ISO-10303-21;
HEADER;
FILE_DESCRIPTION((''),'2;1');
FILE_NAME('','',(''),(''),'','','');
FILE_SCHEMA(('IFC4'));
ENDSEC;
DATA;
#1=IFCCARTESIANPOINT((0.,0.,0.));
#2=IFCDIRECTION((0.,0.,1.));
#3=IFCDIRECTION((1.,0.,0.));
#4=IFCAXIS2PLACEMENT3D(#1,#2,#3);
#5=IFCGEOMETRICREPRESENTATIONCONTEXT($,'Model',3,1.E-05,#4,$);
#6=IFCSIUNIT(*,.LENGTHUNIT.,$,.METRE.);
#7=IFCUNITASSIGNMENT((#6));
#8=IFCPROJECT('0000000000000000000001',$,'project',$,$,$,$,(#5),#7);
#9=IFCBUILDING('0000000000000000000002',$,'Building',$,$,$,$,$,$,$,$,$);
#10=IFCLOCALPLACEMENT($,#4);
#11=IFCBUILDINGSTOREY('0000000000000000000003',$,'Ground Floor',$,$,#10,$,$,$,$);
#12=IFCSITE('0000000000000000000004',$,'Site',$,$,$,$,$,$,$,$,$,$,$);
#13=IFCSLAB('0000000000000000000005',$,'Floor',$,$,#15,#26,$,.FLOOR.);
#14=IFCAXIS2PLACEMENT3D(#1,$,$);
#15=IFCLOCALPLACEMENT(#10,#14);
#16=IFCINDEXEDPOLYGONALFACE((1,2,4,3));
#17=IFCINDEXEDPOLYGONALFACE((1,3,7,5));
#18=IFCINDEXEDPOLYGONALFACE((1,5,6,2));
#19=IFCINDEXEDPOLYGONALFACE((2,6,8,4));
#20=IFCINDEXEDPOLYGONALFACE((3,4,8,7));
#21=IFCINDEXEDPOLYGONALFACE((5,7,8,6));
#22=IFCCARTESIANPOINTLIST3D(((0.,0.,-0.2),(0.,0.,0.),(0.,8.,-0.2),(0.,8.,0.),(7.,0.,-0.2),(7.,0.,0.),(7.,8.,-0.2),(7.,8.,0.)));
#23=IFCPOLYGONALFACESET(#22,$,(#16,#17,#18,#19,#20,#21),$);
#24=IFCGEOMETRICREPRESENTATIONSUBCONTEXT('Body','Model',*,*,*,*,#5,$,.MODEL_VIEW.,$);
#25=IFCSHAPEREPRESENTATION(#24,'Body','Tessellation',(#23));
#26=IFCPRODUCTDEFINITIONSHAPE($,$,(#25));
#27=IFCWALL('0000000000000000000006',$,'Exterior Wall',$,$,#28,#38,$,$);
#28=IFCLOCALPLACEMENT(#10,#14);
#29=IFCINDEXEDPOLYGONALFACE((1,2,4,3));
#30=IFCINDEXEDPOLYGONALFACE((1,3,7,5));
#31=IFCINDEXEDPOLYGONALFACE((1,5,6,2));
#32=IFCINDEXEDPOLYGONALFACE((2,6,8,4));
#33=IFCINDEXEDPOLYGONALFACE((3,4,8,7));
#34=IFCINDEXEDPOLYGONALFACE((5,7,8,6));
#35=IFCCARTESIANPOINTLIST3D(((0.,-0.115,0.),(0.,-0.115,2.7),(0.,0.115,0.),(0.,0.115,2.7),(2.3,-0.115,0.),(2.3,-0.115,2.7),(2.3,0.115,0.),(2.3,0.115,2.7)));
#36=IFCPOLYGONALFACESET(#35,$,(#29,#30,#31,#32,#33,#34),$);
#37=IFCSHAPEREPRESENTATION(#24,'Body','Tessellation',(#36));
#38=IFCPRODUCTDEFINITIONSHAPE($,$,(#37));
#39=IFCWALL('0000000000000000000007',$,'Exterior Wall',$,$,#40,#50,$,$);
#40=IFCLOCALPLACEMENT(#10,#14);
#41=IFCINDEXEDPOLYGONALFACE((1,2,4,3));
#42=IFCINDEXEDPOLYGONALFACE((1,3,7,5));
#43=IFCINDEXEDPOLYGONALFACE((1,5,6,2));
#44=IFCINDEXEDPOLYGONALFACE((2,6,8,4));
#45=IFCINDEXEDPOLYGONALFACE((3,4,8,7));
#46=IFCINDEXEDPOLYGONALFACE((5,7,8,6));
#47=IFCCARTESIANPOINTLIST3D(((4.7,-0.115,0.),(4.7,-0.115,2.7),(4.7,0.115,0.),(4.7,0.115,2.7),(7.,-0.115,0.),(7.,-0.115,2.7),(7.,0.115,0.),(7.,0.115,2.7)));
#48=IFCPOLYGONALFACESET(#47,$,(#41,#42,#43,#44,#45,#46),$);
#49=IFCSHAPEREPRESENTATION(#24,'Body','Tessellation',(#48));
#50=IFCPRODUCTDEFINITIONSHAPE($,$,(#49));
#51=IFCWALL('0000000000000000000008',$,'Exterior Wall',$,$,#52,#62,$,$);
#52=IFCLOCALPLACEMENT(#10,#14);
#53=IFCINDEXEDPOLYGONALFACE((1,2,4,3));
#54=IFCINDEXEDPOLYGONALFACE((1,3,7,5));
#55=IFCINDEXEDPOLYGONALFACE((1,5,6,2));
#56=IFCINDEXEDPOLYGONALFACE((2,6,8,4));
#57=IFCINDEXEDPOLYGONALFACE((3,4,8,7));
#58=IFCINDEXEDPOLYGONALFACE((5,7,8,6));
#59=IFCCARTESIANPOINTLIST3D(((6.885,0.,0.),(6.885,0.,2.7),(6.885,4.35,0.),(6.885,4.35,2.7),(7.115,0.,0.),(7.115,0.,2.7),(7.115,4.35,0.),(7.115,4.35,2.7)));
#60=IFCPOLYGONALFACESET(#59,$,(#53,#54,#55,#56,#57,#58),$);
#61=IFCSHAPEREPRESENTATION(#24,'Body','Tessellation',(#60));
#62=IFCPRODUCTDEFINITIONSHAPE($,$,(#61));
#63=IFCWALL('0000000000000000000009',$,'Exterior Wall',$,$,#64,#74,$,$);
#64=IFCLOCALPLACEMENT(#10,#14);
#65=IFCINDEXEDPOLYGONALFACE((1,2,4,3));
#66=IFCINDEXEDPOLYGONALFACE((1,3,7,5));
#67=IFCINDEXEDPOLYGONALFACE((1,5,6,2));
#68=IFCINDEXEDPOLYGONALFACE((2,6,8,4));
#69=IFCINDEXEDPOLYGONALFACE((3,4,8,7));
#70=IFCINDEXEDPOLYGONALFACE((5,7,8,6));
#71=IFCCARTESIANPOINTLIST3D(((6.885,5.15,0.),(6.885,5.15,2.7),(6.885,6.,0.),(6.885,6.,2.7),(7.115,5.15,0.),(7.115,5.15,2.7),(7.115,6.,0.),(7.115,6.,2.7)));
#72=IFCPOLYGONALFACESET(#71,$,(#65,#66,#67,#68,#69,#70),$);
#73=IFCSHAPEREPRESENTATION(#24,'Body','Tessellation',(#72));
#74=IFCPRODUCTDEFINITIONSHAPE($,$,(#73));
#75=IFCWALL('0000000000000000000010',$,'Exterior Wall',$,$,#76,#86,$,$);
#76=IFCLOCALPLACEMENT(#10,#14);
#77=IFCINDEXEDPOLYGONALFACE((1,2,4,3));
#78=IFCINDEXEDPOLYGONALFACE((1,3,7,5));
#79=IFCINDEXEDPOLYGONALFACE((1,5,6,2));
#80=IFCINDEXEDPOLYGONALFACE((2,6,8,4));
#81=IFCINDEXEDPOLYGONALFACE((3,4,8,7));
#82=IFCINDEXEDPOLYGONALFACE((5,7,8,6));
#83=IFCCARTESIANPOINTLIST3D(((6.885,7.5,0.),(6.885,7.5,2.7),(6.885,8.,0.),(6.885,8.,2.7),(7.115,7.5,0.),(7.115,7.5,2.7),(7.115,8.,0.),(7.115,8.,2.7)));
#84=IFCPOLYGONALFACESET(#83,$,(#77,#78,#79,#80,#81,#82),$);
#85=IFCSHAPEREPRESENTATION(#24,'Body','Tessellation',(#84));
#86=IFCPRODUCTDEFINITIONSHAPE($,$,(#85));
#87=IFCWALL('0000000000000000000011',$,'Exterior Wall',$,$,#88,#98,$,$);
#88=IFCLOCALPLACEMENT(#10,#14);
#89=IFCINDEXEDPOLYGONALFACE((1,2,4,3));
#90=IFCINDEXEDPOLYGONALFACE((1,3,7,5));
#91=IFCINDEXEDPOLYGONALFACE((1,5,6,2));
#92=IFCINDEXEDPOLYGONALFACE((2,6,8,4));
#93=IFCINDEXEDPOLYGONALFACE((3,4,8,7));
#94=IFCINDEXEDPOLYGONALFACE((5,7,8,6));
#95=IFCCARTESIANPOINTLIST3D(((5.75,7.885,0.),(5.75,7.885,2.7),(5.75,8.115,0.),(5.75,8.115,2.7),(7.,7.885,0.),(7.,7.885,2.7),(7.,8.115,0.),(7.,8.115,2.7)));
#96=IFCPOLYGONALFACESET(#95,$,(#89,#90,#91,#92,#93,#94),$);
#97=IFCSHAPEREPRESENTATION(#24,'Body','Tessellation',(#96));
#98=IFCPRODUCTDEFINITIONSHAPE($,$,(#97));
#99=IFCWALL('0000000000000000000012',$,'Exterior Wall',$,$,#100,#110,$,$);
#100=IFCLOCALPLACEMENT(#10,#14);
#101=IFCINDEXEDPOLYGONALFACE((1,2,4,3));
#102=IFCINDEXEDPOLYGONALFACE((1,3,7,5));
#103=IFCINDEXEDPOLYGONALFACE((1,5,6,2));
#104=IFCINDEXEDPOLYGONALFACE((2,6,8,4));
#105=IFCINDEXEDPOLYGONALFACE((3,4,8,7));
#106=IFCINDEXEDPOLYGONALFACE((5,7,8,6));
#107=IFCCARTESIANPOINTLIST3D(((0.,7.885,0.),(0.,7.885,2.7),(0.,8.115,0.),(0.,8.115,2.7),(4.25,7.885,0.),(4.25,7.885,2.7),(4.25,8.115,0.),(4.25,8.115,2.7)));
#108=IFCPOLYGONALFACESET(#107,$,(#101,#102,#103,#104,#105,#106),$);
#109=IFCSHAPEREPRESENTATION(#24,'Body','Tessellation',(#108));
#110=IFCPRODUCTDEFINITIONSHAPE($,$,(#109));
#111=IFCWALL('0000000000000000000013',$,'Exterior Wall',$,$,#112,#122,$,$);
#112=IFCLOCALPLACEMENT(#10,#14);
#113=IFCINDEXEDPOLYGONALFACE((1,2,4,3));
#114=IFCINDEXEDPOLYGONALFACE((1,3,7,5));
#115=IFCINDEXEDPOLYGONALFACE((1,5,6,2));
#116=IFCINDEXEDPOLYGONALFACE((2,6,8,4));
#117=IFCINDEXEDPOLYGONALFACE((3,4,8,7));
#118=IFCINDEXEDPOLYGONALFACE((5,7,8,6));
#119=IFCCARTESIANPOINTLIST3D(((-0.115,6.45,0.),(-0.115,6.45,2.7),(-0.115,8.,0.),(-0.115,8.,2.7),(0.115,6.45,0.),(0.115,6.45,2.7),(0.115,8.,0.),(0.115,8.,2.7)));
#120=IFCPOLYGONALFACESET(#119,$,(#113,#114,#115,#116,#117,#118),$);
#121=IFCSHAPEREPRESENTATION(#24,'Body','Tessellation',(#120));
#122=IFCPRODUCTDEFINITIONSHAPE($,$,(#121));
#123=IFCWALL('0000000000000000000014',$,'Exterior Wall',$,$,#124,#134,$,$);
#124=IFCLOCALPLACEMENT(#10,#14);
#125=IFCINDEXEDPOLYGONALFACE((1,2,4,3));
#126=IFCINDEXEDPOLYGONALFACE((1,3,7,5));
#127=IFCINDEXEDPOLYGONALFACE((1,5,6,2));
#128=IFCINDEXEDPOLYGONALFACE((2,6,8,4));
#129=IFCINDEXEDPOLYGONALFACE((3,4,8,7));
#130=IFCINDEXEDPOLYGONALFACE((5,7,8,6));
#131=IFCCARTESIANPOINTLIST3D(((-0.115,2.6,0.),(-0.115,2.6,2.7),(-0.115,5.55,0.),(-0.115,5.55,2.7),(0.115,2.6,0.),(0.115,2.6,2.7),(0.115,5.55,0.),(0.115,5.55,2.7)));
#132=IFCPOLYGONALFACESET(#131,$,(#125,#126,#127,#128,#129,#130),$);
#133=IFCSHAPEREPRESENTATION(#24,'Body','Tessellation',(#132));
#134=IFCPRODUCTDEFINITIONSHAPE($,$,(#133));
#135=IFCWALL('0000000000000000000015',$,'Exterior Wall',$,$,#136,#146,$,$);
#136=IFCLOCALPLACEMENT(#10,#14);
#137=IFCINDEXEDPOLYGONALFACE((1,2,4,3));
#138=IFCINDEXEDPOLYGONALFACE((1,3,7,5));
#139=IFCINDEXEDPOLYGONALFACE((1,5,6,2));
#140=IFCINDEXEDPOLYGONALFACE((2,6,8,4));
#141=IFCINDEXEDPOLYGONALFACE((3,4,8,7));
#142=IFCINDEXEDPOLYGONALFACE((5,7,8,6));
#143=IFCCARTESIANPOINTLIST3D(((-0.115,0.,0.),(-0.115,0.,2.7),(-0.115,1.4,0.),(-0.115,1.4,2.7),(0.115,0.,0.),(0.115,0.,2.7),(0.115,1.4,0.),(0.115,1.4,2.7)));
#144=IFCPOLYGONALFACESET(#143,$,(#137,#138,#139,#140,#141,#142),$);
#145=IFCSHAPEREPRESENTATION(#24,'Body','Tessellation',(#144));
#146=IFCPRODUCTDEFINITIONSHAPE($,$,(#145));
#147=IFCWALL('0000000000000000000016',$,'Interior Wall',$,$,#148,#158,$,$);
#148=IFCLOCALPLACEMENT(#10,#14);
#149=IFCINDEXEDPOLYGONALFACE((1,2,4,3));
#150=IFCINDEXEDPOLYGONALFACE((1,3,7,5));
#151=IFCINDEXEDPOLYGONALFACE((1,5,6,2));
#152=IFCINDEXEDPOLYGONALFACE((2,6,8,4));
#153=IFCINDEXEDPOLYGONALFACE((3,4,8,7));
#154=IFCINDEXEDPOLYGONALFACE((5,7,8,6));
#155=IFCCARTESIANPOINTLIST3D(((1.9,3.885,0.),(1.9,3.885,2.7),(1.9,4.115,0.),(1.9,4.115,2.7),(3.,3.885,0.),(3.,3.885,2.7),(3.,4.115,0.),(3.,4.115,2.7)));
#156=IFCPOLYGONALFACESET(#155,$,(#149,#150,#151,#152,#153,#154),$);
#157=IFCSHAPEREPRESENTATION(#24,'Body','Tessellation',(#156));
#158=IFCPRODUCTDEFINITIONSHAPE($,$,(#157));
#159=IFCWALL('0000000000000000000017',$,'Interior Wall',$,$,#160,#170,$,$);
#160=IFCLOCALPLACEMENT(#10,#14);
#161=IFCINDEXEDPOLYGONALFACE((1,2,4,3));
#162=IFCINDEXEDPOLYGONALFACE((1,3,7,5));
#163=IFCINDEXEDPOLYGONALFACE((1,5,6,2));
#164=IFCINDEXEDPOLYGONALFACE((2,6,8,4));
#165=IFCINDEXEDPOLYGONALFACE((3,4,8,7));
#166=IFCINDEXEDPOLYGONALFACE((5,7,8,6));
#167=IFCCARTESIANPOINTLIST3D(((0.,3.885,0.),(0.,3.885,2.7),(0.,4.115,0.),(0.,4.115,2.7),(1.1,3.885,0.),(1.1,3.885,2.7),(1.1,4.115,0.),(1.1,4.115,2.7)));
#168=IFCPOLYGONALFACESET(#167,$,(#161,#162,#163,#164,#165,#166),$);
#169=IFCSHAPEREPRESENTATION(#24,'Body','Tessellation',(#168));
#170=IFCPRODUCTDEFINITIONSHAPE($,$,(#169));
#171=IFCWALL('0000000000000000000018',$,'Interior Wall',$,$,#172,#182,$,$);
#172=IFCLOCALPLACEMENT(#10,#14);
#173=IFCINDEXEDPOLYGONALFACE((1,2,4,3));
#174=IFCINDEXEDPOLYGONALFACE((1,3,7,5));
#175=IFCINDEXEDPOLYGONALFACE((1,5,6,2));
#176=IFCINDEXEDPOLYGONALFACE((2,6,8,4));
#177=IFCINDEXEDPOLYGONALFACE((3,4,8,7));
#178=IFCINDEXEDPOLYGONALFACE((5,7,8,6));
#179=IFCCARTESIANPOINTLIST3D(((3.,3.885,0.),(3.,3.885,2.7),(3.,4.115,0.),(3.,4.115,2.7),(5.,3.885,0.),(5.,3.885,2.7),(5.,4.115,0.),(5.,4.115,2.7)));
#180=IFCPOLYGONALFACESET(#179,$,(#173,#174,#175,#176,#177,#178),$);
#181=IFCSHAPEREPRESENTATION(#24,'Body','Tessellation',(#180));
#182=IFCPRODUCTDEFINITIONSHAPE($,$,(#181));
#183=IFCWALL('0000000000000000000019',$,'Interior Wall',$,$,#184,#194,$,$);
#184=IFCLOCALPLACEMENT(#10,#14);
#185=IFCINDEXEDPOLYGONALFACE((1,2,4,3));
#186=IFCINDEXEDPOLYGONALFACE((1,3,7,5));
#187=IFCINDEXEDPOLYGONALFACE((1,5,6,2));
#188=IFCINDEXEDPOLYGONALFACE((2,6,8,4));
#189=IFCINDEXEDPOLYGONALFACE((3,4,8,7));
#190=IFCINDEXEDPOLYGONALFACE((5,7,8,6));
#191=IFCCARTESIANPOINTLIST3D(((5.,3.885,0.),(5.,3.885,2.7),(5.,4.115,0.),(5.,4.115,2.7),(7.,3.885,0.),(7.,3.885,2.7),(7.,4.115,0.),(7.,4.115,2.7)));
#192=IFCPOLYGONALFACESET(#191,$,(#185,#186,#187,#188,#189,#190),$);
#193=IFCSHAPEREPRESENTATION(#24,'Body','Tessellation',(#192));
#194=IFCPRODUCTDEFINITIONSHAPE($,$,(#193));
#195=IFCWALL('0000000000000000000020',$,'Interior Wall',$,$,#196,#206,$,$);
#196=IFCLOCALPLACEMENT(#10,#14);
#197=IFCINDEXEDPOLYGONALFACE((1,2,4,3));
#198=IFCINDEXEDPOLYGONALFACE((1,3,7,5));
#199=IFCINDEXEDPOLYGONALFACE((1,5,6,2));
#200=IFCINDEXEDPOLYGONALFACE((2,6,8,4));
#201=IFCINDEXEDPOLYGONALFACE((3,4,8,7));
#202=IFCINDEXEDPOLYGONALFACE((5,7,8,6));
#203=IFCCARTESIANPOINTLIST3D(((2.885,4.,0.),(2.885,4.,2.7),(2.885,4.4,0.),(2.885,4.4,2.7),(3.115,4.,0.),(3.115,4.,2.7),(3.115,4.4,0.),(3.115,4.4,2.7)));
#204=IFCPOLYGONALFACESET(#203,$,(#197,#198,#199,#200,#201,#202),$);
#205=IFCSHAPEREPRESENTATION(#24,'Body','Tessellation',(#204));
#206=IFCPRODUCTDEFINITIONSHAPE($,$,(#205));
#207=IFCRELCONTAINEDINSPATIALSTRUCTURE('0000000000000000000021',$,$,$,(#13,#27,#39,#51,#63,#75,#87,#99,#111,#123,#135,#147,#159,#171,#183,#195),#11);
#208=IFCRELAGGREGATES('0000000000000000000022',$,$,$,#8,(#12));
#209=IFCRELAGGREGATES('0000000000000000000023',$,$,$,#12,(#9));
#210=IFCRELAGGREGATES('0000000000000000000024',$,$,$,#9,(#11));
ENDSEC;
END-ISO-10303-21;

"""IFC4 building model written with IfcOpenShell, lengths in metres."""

from ifc_helpers import new_model, si_unit, frame, origin_with_axes, place, context, subcontext, project, spatial, indexed_curve, outline, extrude, element, save


model = new_model("IFC4")

# Units and contexts
model_context = context("Model", 3, precision=1e-05, world=origin_with_axes())
body_context = subcontext(model_context, "Body", "Model", "MODEL_VIEW")
ifc_project = project(units=[si_unit("LENGTHUNIT", "METRE")], contexts=[model_context])

# Site, building, storey
site = spatial("IfcSite", under=ifc_project, Name="Site")
building = spatial("IfcBuilding", under=site, Name="Building")
storey_placement = place(None, origin_with_axes())
storey = spatial("IfcBuildingStorey", under=building, at=storey_placement, Name="Ground Floor")

# Slab
slab_placement = place(storey_placement, frame((0.0, 0.0, -0.2), z_axis=(0.0, 0.0, 1.0), x_axis=(1.0, 0.0, 0.0)))
element("IfcSlab", 1, at=slab_placement, inside=storey, Name="Floor", PredefinedType="FLOOR", context=body_context, shape_type="SweptSolid", body=[
    extrude(outline(indexed_curve([(0.0, 0.0), (7.0, 0.0), (7.0, 8.0), (0.0, 8.0)])), None, (0.0, 0.0, 1.0), 0.2),
])

# Walls
for number, where, z_axis, x_axis, name in (
    (2, (0.0, 0.0, 0.0), (0.0, 0.0, 1.0), (1.0, 0.0, 0.0), "Exterior Wall"),
    (3, (4.7, 0.0, 0.0), (0.0, 0.0, 1.0), (1.0, 0.0, 0.0), "Exterior Wall"),
):
    element("IfcWall", number, at=place(storey_placement, frame(where, z_axis=z_axis, x_axis=x_axis)), inside=storey, Name=name, context=body_context, shape_type="SweptSolid", body=[
        extrude(outline(indexed_curve([(0.0, 0.0), (0.0, 0.23), (2.3, 0.23), (2.3, 0.0), (0.0, 0.0)], self_intersect=False)), frame((0.0, -0.115, 0.0), z_axis=(0.0, 0.0, 1.0), x_axis=(1.0, 0.0, 0.0)), (0.0, 0.0, 1.0), 2.7),
    ])
wall_1_placement = place(storey_placement, frame((7.0, 0.0, 0.0), z_axis=(0.0, 0.0, 1.0), x_axis=(0.0, 1.0, 0.0)))
element("IfcWall", 4, at=wall_1_placement, inside=storey, Name="Exterior Wall", context=body_context, shape_type="SweptSolid", body=[
    extrude(outline(indexed_curve([(0.0, 0.0), (0.0, 0.23), (4.35, 0.23), (4.35, 0.0), (0.0, 0.0)], self_intersect=False)), frame((0.0, -0.115, 0.0), z_axis=(0.0, 0.0, 1.0), x_axis=(1.0, 0.0, 0.0)), (0.0, 0.0, 1.0), 2.7),
])
wall_2_placement = place(storey_placement, frame((7.0, 5.15, 0.0), z_axis=(0.0, 0.0, 1.0), x_axis=(0.0, 1.0, 0.0)))
element("IfcWall", 5, at=wall_2_placement, inside=storey, Name="Exterior Wall", context=body_context, shape_type="SweptSolid", body=[
    extrude(outline(indexed_curve([(0.0, 0.0), (0.0, 0.23), (0.85, 0.23), (0.85, 0.0), (0.0, 0.0)], self_intersect=False)), frame((0.0, -0.115, 0.0), z_axis=(0.0, 0.0, 1.0), x_axis=(1.0, 0.0, 0.0)), (0.0, 0.0, 1.0), 2.7),
])
wall_3_placement = place(storey_placement, frame((7.0, 7.5, 0.0), z_axis=(0.0, 0.0, 1.0), x_axis=(0.0, 1.0, 0.0)))
element("IfcWall", 6, at=wall_3_placement, inside=storey, Name="Exterior Wall", context=body_context, shape_type="SweptSolid", body=[
    extrude(outline(indexed_curve([(0.0, 0.0), (0.0, 0.23), (0.5, 0.23), (0.5, 0.0), (0.0, 0.0)], self_intersect=False)), frame((0.0, -0.115, 0.0), z_axis=(0.0, 0.0, 1.0), x_axis=(1.0, 0.0, 0.0)), (0.0, 0.0, 1.0), 2.7),
])
wall_4_placement = place(storey_placement, frame((7.0, 8.0, 0.0), z_axis=(0.0, 0.0, 1.0), x_axis=(-1.0, 0.0, 0.0)))
element("IfcWall", 7, at=wall_4_placement, inside=storey, Name="Exterior Wall", context=body_context, shape_type="SweptSolid", body=[
    extrude(outline(indexed_curve([(0.0, 0.0), (0.0, 0.23), (1.25, 0.23), (1.25, 0.0), (0.0, 0.0)], self_intersect=False)), frame((0.0, -0.115, 0.0), z_axis=(0.0, 0.0, 1.0), x_axis=(1.0, 0.0, 0.0)), (0.0, 0.0, 1.0), 2.7),
])
wall_5_placement = place(storey_placement, frame((4.25, 8.0, 0.0), z_axis=(0.0, 0.0, 1.0), x_axis=(-1.0, 0.0, 0.0)))
element("IfcWall", 8, at=wall_5_placement, inside=storey, Name="Exterior Wall", context=body_context, shape_type="SweptSolid", body=[
    extrude(outline(indexed_curve([(0.0, 0.0), (0.0, 0.23), (4.25, 0.23), (4.25, 0.0), (0.0, 0.0)], self_intersect=False)), frame((0.0, -0.115, 0.0), z_axis=(0.0, 0.0, 1.0), x_axis=(1.0, 0.0, 0.0)), (0.0, 0.0, 1.0), 2.7),
])
wall_6_placement = place(storey_placement, frame((0.0, 8.0, 0.0), z_axis=(0.0, 0.0, 1.0), x_axis=(0.0, -1.0, 0.0)))
element("IfcWall", 9, at=wall_6_placement, inside=storey, Name="Exterior Wall", context=body_context, shape_type="SweptSolid", body=[
    extrude(outline(indexed_curve([(0.0, 0.0), (0.0, 0.23), (1.55, 0.23), (1.55, 0.0), (0.0, 0.0)], self_intersect=False)), frame((0.0, -0.115, 0.0), z_axis=(0.0, 0.0, 1.0), x_axis=(1.0, 0.0, 0.0)), (0.0, 0.0, 1.0), 2.7),
])
wall_7_placement = place(storey_placement, frame((0.0, 5.55, 0.0), z_axis=(0.0, 0.0, 1.0), x_axis=(0.0, -1.0, 0.0)))
element("IfcWall", 10, at=wall_7_placement, inside=storey, Name="Exterior Wall", context=body_context, shape_type="SweptSolid", body=[
    extrude(outline(indexed_curve([(0.0, 0.0), (0.0, 0.23), (2.95, 0.23), (2.95, 0.0), (0.0, 0.0)], self_intersect=False)), frame((0.0, -0.115, 0.0), z_axis=(0.0, 0.0, 1.0), x_axis=(1.0, 0.0, 0.0)), (0.0, 0.0, 1.0), 2.7),
])
wall_8_placement = place(storey_placement, frame((0.0, 1.4, 0.0), z_axis=(0.0, 0.0, 1.0), x_axis=(0.0, -1.0, 0.0)))
element("IfcWall", 11, at=wall_8_placement, inside=storey, Name="Exterior Wall", context=body_context, shape_type="SweptSolid", body=[
    extrude(outline(indexed_curve([(0.0, 0.0), (0.0, 0.23), (1.4, 0.23), (1.4, 0.0), (0.0, 0.0)], self_intersect=False)), frame((0.0, -0.115, 0.0), z_axis=(0.0, 0.0, 1.0), x_axis=(1.0, 0.0, 0.0)), (0.0, 0.0, 1.0), 2.7),
])
for number, where, z_axis, x_axis, name in (
    (12, (3.0, 4.0, 0.0), (0.0, 0.0, 1.0), (-1.0, 0.0, 0.0), "Interior Wall"),
    (13, (1.1, 4.0, 0.0), (0.0, 0.0, 1.0), (-1.0, 0.0, 0.0), "Interior Wall"),
):
    element("IfcWall", number, at=place(storey_placement, frame(where, z_axis=z_axis, x_axis=x_axis)), inside=storey, Name=name, context=body_context, shape_type="SweptSolid", body=[
        extrude(outline(indexed_curve([(0.0, 0.0), (0.0, 0.23), (1.1, 0.23), (1.1, 0.0), (0.0, 0.0)], self_intersect=False)), frame((0.0, -0.115, 0.0), z_axis=(0.0, 0.0, 1.0), x_axis=(1.0, 0.0, 0.0)), (0.0, 0.0, 1.0), 2.7),
    ])
for number, where, z_axis, x_axis, name in (
    (14, (5.0, 4.0, 0.0), (0.0, 0.0, 1.0), (-1.0, 0.0, 0.0), "Interior Wall"),
    (15, (7.0, 4.0, 0.0), (0.0, 0.0, 1.0), (-1.0, 0.0, 0.0), "Interior Wall"),
):
    element("IfcWall", number, at=place(storey_placement, frame(where, z_axis=z_axis, x_axis=x_axis)), inside=storey, Name=name, context=body_context, shape_type="SweptSolid", body=[
        extrude(outline(indexed_curve([(0.0, 0.0), (0.0, 0.23), (2.0, 0.23), (2.0, 0.0), (0.0, 0.0)], self_intersect=False)), frame((0.0, -0.115, 0.0), z_axis=(0.0, 0.0, 1.0), x_axis=(1.0, 0.0, 0.0)), (0.0, 0.0, 1.0), 2.7),
    ])
for number, where, z_axis, x_axis, name in (
    (16, (3.0, 4.0, 0.0), (0.0, 0.0, 1.0), (0.0, 1.0, 0.0), "Interior Wall"),
):
    element("IfcWall", number, at=place(storey_placement, frame(where, z_axis=z_axis, x_axis=x_axis)), inside=storey, Name=name, context=body_context, shape_type="SweptSolid", body=[
        extrude(outline(indexed_curve([(0.0, 0.0), (0.0, 0.23), (0.4, 0.23), (0.4, 0.0), (0.0, 0.0)], self_intersect=False)), frame((0.0, -0.115, 0.0), z_axis=(0.0, 0.0, 1.0), x_axis=(1.0, 0.0, 0.0)), (0.0, 0.0, 1.0), 2.7),
    ])

save(model, "model.ifc")
